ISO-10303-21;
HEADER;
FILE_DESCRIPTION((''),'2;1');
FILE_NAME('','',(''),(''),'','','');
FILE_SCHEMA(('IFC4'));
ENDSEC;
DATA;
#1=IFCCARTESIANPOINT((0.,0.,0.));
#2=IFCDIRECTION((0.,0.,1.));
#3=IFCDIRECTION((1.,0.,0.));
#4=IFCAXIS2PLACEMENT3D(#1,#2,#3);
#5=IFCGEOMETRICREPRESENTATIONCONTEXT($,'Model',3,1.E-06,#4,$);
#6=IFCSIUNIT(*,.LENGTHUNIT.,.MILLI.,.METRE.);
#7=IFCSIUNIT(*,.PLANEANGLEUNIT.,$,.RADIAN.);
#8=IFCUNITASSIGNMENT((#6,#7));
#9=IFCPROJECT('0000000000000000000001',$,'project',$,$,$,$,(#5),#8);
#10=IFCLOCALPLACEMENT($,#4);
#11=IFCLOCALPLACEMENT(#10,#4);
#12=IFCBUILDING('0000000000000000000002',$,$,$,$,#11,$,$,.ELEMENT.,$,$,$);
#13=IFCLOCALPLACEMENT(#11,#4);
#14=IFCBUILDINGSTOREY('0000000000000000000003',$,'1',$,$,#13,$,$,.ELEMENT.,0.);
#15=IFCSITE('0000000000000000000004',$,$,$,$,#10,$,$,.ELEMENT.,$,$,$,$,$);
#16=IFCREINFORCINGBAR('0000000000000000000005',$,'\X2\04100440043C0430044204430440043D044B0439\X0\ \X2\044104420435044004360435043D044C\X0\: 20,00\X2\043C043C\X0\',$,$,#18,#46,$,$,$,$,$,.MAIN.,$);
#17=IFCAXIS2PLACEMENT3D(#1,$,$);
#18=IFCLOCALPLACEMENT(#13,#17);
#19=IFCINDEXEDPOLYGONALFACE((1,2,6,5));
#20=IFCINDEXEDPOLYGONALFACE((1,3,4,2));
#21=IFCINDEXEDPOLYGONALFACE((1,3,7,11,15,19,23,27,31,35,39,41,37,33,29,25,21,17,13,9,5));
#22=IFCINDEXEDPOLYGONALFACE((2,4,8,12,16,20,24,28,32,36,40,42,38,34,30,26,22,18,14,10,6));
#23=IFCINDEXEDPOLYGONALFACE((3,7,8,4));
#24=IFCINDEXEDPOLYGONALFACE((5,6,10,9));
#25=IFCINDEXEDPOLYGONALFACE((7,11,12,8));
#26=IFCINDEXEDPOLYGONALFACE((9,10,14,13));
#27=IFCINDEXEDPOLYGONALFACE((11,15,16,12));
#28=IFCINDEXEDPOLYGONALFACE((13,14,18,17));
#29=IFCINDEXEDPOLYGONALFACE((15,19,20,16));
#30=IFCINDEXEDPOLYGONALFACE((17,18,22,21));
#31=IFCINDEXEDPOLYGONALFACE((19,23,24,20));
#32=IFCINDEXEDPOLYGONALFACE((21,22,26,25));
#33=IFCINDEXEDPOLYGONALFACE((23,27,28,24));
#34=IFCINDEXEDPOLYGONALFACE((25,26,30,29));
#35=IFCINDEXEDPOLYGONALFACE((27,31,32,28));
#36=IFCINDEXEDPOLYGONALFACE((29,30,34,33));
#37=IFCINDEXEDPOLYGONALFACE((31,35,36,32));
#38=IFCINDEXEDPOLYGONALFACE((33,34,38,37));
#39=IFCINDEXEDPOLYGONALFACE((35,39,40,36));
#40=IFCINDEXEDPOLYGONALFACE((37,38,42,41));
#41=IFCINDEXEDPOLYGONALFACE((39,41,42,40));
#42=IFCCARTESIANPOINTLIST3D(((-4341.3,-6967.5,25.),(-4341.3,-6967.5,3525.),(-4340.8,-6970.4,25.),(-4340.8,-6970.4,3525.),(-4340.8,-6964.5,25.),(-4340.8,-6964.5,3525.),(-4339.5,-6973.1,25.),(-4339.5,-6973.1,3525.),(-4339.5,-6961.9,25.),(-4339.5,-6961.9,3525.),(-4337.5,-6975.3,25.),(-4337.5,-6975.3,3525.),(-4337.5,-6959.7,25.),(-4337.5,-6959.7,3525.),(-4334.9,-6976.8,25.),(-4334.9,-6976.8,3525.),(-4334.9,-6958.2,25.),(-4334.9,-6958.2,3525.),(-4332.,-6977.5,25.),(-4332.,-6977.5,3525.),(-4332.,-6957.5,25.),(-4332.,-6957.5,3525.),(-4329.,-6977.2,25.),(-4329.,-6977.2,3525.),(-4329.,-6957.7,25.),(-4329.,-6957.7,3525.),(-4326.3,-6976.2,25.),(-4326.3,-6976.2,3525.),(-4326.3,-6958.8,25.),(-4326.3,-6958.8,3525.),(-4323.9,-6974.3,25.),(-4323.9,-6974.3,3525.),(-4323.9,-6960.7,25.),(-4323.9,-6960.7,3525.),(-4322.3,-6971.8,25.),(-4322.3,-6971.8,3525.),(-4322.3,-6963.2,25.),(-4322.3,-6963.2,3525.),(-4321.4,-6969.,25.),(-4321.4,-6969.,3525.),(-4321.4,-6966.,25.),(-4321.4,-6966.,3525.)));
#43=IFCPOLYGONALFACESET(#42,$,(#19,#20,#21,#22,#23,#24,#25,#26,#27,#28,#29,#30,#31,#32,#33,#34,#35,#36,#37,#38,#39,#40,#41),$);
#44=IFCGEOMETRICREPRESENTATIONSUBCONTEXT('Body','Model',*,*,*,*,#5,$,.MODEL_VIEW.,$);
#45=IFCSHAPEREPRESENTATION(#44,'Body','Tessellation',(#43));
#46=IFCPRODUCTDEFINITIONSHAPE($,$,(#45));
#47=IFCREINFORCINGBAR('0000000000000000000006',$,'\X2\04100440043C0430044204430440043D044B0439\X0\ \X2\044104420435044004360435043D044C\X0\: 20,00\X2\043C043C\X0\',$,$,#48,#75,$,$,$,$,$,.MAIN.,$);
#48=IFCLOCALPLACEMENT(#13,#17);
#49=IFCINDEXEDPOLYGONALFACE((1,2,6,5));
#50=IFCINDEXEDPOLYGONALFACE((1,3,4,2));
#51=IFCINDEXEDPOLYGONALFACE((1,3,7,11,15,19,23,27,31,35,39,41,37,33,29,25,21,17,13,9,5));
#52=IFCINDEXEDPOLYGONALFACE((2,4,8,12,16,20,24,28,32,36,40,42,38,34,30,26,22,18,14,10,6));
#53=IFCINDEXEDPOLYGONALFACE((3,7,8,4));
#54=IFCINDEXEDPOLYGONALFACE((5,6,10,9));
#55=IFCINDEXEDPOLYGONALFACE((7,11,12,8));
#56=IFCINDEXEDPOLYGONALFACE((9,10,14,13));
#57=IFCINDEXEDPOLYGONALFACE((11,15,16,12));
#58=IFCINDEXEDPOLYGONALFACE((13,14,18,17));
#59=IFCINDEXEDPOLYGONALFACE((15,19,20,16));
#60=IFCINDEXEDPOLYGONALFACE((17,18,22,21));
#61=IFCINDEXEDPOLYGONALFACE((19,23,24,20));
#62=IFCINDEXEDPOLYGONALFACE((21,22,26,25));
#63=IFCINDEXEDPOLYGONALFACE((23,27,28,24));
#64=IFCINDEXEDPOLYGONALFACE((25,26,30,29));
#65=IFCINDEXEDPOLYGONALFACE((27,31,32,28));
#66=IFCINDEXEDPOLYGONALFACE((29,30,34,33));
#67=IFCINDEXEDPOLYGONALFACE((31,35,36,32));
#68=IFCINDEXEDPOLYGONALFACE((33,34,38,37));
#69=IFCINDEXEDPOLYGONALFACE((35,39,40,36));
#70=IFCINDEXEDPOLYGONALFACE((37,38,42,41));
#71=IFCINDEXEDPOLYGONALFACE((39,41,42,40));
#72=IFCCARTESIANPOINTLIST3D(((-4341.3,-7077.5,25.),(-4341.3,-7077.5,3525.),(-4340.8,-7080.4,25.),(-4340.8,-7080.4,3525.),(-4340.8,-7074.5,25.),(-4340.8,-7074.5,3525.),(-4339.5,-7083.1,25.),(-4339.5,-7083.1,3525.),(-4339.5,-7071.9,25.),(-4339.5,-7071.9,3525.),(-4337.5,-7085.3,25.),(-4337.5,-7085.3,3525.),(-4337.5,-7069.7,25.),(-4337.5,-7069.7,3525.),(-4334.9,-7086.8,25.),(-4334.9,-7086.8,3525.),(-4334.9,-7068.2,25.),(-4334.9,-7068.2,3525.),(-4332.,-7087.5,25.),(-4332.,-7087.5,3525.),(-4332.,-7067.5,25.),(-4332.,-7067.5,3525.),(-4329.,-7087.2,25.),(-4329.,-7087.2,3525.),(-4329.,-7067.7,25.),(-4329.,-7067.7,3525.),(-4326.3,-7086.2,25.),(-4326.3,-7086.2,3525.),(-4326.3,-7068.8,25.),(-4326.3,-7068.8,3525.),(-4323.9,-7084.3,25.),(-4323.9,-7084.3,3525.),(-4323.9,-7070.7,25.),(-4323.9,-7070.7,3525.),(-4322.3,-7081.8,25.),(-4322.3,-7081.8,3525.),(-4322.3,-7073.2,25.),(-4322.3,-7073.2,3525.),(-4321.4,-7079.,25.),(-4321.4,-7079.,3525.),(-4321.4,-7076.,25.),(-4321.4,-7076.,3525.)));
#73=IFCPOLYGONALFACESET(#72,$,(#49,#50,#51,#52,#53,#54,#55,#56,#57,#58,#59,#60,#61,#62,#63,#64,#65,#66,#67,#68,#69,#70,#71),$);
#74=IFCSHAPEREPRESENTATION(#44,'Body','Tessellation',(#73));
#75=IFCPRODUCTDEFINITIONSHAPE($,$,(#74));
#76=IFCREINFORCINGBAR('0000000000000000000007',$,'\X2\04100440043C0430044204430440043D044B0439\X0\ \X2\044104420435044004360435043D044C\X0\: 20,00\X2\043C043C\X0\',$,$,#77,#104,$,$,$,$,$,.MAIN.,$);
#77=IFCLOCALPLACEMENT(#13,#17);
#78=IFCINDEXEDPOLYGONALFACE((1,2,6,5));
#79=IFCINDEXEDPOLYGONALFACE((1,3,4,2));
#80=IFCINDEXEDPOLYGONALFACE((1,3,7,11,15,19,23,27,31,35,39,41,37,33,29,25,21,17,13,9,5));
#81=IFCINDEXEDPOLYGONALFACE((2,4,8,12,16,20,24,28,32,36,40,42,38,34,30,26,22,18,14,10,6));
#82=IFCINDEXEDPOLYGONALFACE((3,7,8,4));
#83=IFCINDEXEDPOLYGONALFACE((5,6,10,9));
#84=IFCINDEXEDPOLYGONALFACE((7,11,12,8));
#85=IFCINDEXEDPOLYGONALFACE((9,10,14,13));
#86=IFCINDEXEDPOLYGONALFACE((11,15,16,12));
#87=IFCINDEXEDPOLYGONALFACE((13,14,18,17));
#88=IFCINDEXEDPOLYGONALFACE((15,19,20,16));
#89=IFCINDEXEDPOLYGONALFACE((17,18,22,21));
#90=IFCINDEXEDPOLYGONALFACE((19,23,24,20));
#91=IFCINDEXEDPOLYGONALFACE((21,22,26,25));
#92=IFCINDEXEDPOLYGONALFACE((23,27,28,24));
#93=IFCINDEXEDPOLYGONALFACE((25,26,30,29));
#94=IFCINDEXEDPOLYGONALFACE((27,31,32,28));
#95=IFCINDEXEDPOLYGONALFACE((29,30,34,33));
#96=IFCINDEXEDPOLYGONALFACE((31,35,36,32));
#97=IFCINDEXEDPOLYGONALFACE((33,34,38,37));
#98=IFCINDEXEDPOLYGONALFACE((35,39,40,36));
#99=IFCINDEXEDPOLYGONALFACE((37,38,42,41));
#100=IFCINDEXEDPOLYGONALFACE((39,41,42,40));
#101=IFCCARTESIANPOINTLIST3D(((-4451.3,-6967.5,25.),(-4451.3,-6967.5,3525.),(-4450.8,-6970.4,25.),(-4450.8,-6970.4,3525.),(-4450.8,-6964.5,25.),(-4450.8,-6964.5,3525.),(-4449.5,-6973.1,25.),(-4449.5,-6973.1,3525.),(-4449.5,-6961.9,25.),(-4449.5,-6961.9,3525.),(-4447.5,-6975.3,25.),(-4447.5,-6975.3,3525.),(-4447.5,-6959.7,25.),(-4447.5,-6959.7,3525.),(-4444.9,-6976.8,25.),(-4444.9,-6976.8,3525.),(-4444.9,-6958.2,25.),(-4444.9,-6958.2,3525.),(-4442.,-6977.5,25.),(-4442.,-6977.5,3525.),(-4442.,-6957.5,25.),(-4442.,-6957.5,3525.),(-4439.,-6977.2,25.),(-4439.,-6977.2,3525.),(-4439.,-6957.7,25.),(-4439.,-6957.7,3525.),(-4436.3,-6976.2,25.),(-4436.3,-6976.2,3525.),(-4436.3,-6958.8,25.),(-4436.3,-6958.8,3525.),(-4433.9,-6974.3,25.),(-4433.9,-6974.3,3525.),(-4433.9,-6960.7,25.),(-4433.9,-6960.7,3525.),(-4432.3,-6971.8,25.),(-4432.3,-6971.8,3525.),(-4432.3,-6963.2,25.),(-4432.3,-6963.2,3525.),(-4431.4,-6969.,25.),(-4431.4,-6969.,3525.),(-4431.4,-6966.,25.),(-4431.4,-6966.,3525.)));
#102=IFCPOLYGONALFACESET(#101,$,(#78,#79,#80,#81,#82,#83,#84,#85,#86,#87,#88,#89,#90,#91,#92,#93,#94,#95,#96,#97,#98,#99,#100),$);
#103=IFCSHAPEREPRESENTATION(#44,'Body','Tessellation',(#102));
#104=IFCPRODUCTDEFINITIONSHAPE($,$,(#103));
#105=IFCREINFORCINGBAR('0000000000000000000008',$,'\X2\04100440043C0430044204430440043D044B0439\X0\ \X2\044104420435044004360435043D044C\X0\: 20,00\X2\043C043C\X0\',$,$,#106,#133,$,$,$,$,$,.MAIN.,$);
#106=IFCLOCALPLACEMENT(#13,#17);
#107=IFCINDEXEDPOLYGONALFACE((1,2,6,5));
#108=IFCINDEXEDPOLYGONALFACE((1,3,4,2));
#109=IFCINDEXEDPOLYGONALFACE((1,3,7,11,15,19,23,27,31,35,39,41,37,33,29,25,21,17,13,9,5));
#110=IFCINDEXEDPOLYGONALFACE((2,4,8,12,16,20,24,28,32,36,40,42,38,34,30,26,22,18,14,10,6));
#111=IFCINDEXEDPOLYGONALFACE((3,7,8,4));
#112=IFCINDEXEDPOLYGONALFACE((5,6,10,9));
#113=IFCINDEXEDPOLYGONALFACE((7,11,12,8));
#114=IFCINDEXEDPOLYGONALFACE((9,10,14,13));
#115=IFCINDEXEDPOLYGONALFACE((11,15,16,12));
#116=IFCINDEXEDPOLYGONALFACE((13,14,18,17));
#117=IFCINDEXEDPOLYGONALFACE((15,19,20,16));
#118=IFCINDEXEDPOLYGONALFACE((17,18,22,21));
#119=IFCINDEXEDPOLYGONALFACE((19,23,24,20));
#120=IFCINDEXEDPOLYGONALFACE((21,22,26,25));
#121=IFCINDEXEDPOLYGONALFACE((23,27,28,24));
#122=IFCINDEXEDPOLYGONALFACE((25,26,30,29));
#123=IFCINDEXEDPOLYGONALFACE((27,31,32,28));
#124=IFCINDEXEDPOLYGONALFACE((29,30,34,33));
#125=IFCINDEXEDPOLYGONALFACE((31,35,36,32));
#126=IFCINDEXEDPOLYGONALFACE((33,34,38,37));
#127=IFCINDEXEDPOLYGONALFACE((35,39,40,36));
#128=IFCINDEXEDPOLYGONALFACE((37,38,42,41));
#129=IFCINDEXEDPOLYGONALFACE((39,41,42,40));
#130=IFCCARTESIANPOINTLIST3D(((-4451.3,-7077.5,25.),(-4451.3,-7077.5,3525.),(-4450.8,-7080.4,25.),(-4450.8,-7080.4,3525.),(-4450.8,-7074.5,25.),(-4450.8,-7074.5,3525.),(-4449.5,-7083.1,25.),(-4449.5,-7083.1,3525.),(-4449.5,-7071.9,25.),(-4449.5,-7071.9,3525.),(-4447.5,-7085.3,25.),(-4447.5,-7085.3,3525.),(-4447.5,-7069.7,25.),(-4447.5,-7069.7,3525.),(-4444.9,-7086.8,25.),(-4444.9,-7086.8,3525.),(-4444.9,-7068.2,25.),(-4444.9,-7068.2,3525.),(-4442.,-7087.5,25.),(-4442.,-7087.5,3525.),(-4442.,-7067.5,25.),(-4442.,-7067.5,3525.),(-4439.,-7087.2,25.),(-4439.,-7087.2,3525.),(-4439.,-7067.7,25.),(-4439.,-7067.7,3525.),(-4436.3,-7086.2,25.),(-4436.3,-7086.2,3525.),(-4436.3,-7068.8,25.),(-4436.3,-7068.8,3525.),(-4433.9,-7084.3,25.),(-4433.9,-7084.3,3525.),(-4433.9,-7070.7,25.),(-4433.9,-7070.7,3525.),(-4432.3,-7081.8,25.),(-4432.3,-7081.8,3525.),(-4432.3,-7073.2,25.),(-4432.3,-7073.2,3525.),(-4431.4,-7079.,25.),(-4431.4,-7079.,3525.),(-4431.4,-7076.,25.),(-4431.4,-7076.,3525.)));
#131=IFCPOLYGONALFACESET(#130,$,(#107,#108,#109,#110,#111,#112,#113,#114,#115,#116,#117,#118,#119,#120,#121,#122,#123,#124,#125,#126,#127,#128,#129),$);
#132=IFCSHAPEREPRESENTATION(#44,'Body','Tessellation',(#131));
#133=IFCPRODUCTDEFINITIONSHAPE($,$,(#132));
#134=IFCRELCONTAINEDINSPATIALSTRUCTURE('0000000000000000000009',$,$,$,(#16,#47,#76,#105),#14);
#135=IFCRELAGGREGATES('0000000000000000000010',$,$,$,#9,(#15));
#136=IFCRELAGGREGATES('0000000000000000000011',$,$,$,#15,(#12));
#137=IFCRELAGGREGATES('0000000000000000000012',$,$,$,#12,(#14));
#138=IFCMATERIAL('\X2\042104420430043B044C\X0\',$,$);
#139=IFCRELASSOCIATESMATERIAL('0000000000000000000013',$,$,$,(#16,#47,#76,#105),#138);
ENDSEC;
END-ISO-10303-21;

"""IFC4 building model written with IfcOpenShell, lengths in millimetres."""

from ifc_helpers import new_model, entity, si_unit, origin_with_axes, place, context, subcontext, project, spatial, source, transform, mapped, material, element, save


model = new_model("IFC4")

# Units and contexts
model_context = context("Model", 3, precision=1e-06, world=origin_with_axes())
body_context = subcontext(model_context, "Body", "Model", "MODEL_VIEW")
ifc_project = project(units=[si_unit("LENGTHUNIT", "METRE", prefix="MILLI"), si_unit("PLANEANGLEUNIT", "RADIAN")], contexts=[model_context])

# Site, building, storey
site_placement = place(None, origin_with_axes())
site = spatial("IfcSite", under=ifc_project, at=site_placement, CompositionType="ELEMENT")
building_placement = place(site_placement, origin_with_axes())
building = spatial("IfcBuilding", under=site, at=building_placement, CompositionType="ELEMENT")
storey_placement = place(building_placement, origin_with_axes())
storey = spatial("IfcBuildingStorey", under=building, at=storey_placement, Name="1", CompositionType="ELEMENT", Elevation=0.0)

# Reinforcing bars
ifc_material = material(Name="Сталь")
shared_shape_1 = source(origin_with_axes(), body_context, "Body", "AdvancedSweptSolid", [
    entity("IfcSweptDiskSolid", entity("IfcIndexedPolyCurve", entity("IfcCartesianPointList3D", [[0.0, 0.0, 0.0], [3500.0, 0.0, 0.0]]), [entity("IfcLineIndex", [1, 2])]), 10.0),
])
reinforcing_bar_1_placement = place(storey_placement, origin_with_axes())
element("IfcReinforcingBar", 1, at=reinforcing_bar_1_placement, inside=storey, material=ifc_material, Name="Арматурный стержень: 20,00мм", PredefinedType="MAIN", context=body_context, shape_type="MappedRepresentation", body=[
    mapped(shared_shape_1, transform((-4331.3, -6967.5, 25.0), x_axis=(0.0, 0.0, 1.0), y_axis=(0.0, 1.0, 0.0), z_axis=(-1.0, 0.0, 0.0), scale=1.0)),
])
reinforcing_bar_2_placement = place(storey_placement, origin_with_axes())
element("IfcReinforcingBar", 2, at=reinforcing_bar_2_placement, inside=storey, material=ifc_material, Name="Арматурный стержень: 20,00мм", PredefinedType="MAIN", context=body_context, shape_type="MappedRepresentation", body=[
    mapped(shared_shape_1, transform((-4331.3, -7077.5, 25.0), x_axis=(0.0, 0.0, 1.0), y_axis=(0.0, 1.0, 0.0), z_axis=(-1.0, 0.0, 0.0), scale=1.0)),
])
reinforcing_bar_3_placement = place(storey_placement, origin_with_axes())
element("IfcReinforcingBar", 3, at=reinforcing_bar_3_placement, inside=storey, material=ifc_material, Name="Арматурный стержень: 20,00мм", PredefinedType="MAIN", context=body_context, shape_type="MappedRepresentation", body=[
    mapped(shared_shape_1, transform((-4441.3, -6967.5, 25.0), x_axis=(0.0, 0.0, 1.0), y_axis=(0.0, 1.0, 0.0), z_axis=(-1.0, 0.0, 0.0), scale=1.0)),
])
reinforcing_bar_4_placement = place(storey_placement, origin_with_axes())
element("IfcReinforcingBar", 4, at=reinforcing_bar_4_placement, inside=storey, material=ifc_material, Name="Арматурный стержень: 20,00мм", PredefinedType="MAIN", context=body_context, shape_type="MappedRepresentation", body=[
    mapped(shared_shape_1, transform((-4441.3, -7077.5, 25.0), x_axis=(0.0, 0.0, 1.0), y_axis=(0.0, 1.0, 0.0), z_axis=(-1.0, 0.0, 0.0), scale=1.0)),
])

save(model, "model.ifc")
